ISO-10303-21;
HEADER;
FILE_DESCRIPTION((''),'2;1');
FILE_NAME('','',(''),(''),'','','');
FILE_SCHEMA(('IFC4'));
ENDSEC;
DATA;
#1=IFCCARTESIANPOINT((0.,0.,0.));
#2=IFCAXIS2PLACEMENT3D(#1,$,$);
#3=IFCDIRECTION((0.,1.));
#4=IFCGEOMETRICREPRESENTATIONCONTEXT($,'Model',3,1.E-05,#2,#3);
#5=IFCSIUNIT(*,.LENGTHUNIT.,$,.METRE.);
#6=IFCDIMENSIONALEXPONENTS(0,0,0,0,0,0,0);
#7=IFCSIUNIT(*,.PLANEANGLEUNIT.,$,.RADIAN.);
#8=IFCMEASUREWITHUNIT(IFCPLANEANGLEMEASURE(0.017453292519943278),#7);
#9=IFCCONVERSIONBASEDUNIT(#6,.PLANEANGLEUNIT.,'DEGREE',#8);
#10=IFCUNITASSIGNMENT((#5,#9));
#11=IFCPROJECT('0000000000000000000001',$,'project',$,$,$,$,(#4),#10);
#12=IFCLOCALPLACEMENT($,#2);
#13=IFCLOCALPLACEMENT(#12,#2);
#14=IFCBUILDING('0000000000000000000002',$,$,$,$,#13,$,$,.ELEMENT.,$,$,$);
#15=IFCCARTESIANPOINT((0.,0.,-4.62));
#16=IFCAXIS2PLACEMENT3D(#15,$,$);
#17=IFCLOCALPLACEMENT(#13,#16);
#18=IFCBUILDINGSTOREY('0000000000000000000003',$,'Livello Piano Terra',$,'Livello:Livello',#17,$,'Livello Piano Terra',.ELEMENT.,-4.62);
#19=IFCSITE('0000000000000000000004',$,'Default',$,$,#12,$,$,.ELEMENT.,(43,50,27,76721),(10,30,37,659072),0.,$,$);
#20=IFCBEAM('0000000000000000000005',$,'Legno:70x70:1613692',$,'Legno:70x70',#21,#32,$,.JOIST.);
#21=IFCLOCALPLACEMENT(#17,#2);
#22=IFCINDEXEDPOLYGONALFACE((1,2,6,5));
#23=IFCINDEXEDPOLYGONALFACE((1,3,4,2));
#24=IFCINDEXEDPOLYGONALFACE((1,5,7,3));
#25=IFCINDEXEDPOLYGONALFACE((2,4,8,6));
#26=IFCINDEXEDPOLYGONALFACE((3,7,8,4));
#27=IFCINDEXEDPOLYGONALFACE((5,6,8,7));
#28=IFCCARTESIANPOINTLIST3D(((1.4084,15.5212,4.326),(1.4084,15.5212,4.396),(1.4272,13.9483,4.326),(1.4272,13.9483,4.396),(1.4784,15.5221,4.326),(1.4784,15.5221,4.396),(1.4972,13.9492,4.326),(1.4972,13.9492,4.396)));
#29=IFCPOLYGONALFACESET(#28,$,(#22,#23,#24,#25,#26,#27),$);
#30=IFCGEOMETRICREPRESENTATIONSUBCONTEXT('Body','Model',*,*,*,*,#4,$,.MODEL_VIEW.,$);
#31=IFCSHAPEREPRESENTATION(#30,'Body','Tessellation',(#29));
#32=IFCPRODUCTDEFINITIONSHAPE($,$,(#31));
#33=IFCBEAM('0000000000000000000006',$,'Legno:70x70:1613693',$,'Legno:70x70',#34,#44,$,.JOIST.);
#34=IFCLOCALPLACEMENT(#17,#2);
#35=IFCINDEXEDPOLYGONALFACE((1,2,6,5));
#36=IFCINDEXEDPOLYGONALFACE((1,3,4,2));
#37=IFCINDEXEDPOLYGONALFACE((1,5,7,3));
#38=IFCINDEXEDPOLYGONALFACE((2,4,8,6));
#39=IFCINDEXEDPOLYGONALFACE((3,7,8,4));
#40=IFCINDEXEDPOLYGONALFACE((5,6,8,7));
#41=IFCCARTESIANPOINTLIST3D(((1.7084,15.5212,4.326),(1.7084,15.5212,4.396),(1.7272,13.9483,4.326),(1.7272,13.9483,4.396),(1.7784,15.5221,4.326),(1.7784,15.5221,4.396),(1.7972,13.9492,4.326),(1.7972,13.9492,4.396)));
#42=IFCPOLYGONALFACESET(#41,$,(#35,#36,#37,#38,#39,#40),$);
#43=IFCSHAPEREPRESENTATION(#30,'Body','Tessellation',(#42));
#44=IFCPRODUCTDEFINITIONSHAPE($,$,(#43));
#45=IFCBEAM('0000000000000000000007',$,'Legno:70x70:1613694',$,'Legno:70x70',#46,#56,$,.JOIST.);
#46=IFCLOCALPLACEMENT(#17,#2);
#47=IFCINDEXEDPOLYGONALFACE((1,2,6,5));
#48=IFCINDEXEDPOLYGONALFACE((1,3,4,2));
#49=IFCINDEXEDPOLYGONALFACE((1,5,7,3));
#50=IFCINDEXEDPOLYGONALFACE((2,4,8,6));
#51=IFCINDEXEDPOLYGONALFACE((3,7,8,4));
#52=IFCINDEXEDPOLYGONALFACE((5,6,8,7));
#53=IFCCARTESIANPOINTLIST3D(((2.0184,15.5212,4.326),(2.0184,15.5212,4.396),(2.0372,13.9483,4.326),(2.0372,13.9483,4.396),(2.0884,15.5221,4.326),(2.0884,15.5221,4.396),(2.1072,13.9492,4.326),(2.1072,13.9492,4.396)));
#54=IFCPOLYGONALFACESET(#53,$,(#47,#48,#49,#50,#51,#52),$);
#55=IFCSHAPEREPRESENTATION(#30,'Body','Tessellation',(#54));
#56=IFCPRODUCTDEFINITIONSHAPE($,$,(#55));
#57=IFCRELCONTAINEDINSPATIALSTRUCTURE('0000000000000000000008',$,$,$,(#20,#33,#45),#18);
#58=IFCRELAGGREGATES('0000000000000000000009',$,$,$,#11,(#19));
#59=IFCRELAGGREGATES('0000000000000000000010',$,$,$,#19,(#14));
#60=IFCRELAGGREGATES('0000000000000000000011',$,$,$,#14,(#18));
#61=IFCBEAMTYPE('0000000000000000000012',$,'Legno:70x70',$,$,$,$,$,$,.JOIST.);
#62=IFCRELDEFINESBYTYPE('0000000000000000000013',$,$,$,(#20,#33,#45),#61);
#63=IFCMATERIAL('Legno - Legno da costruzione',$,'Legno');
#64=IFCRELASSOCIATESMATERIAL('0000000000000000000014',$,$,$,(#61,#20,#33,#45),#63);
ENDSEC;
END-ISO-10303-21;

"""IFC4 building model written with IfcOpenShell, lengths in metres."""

from ifc_helpers import new_model, entity, si_unit, converted_unit, direction, frame, origin, place, context, subcontext, project, spatial, indexed_curve, outline, extrude, source, transform, mapped, material, type_object, type_shapes, element, save


model = new_model("IFC4")

# Units and contexts
model_context = context("Model", 3, precision=1e-05, world=origin(), true_north=direction((0.0, 1.0)))
body_context = subcontext(model_context, "Body", "Model", "MODEL_VIEW")
ifc_project = project(units=[si_unit("LENGTHUNIT", "METRE"), converted_unit("PLANEANGLEUNIT", "DEGREE", entity("IfcPlaneAngleMeasure", 0.017453292519943278), si_unit("PLANEANGLEUNIT", "RADIAN"), dimensions=[0, 0, 0, 0, 0, 0, 0])], contexts=[model_context])

# Site, building, storey
site_placement = place(None, origin())
site = spatial("IfcSite", under=ifc_project, at=site_placement, Name="Default", CompositionType="ELEMENT", RefLatitude=(43, 50, 27, 76721), RefLongitude=(10, 30, 37, 659072), RefElevation=0.0)
building_placement = place(site_placement, origin())
building = spatial("IfcBuilding", under=site, at=building_placement, CompositionType="ELEMENT")
storey_placement = place(building_placement, frame((0.0, 0.0, -4.62)))
storey = spatial("IfcBuildingStorey", under=building, at=storey_placement, Name="Livello Piano Terra", ObjectType="Livello:Livello", LongName="Livello Piano Terra", CompositionType="ELEMENT", Elevation=-4.62)

# Beams
ifc_material = material(Name="Legno - Legno da costruzione", Category="Legno")
beam_type_1 = type_object("IfcBeamType", Name="Legno:70x70", PredefinedType="JOIST", material=ifc_material)
shared_shape_1 = source(origin(), body_context, "Body", "SweptSolid", [
    extrude(outline(indexed_curve([(-0.7865, -0.035), (0.7865, -0.035), (0.7865, 0.035), (-0.7865, 0.035), (-0.7865, -0.035)], self_intersect=False)), frame((0.0, 0.0, -0.035), z_axis=(0.0, 0.0, 1.0), x_axis=(-1.0, 0.0, 0.0)), (0.0, 0.0, 1.0), 0.07),
])
type_shapes(beam_type_1, [shared_shape_1])
for number, where, z_axis, x_axis, name in (
    (1, (1.4528, 14.7352, 4.361), (0.0, 0.0, 1.0), (0.011914, -0.999929, 0.0), "Legno:70x70:1613692"),
    (2, (1.7528, 14.7352, 4.361), (0.0, 0.0, 1.0), (0.011914, -0.999929, 0.0), "Legno:70x70:1613693"),
    (3, (2.0628, 14.7352, 4.361), (0.0, 0.0, 1.0), (0.011914, -0.999929, 0.0), "Legno:70x70:1613694"),
):
    element("IfcBeam", number, at=place(storey_placement, frame(where, z_axis=z_axis, x_axis=x_axis)), inside=storey, type_object=beam_type_1, material=ifc_material, Name=name, ObjectType="Legno:70x70", PredefinedType="JOIST", context=body_context, shape_type="MappedRepresentation", body=[
        mapped(shared_shape_1, transform((0.0, 0.0, 0.0), scale=1.0)),
    ])

save(model, "model.ifc")
